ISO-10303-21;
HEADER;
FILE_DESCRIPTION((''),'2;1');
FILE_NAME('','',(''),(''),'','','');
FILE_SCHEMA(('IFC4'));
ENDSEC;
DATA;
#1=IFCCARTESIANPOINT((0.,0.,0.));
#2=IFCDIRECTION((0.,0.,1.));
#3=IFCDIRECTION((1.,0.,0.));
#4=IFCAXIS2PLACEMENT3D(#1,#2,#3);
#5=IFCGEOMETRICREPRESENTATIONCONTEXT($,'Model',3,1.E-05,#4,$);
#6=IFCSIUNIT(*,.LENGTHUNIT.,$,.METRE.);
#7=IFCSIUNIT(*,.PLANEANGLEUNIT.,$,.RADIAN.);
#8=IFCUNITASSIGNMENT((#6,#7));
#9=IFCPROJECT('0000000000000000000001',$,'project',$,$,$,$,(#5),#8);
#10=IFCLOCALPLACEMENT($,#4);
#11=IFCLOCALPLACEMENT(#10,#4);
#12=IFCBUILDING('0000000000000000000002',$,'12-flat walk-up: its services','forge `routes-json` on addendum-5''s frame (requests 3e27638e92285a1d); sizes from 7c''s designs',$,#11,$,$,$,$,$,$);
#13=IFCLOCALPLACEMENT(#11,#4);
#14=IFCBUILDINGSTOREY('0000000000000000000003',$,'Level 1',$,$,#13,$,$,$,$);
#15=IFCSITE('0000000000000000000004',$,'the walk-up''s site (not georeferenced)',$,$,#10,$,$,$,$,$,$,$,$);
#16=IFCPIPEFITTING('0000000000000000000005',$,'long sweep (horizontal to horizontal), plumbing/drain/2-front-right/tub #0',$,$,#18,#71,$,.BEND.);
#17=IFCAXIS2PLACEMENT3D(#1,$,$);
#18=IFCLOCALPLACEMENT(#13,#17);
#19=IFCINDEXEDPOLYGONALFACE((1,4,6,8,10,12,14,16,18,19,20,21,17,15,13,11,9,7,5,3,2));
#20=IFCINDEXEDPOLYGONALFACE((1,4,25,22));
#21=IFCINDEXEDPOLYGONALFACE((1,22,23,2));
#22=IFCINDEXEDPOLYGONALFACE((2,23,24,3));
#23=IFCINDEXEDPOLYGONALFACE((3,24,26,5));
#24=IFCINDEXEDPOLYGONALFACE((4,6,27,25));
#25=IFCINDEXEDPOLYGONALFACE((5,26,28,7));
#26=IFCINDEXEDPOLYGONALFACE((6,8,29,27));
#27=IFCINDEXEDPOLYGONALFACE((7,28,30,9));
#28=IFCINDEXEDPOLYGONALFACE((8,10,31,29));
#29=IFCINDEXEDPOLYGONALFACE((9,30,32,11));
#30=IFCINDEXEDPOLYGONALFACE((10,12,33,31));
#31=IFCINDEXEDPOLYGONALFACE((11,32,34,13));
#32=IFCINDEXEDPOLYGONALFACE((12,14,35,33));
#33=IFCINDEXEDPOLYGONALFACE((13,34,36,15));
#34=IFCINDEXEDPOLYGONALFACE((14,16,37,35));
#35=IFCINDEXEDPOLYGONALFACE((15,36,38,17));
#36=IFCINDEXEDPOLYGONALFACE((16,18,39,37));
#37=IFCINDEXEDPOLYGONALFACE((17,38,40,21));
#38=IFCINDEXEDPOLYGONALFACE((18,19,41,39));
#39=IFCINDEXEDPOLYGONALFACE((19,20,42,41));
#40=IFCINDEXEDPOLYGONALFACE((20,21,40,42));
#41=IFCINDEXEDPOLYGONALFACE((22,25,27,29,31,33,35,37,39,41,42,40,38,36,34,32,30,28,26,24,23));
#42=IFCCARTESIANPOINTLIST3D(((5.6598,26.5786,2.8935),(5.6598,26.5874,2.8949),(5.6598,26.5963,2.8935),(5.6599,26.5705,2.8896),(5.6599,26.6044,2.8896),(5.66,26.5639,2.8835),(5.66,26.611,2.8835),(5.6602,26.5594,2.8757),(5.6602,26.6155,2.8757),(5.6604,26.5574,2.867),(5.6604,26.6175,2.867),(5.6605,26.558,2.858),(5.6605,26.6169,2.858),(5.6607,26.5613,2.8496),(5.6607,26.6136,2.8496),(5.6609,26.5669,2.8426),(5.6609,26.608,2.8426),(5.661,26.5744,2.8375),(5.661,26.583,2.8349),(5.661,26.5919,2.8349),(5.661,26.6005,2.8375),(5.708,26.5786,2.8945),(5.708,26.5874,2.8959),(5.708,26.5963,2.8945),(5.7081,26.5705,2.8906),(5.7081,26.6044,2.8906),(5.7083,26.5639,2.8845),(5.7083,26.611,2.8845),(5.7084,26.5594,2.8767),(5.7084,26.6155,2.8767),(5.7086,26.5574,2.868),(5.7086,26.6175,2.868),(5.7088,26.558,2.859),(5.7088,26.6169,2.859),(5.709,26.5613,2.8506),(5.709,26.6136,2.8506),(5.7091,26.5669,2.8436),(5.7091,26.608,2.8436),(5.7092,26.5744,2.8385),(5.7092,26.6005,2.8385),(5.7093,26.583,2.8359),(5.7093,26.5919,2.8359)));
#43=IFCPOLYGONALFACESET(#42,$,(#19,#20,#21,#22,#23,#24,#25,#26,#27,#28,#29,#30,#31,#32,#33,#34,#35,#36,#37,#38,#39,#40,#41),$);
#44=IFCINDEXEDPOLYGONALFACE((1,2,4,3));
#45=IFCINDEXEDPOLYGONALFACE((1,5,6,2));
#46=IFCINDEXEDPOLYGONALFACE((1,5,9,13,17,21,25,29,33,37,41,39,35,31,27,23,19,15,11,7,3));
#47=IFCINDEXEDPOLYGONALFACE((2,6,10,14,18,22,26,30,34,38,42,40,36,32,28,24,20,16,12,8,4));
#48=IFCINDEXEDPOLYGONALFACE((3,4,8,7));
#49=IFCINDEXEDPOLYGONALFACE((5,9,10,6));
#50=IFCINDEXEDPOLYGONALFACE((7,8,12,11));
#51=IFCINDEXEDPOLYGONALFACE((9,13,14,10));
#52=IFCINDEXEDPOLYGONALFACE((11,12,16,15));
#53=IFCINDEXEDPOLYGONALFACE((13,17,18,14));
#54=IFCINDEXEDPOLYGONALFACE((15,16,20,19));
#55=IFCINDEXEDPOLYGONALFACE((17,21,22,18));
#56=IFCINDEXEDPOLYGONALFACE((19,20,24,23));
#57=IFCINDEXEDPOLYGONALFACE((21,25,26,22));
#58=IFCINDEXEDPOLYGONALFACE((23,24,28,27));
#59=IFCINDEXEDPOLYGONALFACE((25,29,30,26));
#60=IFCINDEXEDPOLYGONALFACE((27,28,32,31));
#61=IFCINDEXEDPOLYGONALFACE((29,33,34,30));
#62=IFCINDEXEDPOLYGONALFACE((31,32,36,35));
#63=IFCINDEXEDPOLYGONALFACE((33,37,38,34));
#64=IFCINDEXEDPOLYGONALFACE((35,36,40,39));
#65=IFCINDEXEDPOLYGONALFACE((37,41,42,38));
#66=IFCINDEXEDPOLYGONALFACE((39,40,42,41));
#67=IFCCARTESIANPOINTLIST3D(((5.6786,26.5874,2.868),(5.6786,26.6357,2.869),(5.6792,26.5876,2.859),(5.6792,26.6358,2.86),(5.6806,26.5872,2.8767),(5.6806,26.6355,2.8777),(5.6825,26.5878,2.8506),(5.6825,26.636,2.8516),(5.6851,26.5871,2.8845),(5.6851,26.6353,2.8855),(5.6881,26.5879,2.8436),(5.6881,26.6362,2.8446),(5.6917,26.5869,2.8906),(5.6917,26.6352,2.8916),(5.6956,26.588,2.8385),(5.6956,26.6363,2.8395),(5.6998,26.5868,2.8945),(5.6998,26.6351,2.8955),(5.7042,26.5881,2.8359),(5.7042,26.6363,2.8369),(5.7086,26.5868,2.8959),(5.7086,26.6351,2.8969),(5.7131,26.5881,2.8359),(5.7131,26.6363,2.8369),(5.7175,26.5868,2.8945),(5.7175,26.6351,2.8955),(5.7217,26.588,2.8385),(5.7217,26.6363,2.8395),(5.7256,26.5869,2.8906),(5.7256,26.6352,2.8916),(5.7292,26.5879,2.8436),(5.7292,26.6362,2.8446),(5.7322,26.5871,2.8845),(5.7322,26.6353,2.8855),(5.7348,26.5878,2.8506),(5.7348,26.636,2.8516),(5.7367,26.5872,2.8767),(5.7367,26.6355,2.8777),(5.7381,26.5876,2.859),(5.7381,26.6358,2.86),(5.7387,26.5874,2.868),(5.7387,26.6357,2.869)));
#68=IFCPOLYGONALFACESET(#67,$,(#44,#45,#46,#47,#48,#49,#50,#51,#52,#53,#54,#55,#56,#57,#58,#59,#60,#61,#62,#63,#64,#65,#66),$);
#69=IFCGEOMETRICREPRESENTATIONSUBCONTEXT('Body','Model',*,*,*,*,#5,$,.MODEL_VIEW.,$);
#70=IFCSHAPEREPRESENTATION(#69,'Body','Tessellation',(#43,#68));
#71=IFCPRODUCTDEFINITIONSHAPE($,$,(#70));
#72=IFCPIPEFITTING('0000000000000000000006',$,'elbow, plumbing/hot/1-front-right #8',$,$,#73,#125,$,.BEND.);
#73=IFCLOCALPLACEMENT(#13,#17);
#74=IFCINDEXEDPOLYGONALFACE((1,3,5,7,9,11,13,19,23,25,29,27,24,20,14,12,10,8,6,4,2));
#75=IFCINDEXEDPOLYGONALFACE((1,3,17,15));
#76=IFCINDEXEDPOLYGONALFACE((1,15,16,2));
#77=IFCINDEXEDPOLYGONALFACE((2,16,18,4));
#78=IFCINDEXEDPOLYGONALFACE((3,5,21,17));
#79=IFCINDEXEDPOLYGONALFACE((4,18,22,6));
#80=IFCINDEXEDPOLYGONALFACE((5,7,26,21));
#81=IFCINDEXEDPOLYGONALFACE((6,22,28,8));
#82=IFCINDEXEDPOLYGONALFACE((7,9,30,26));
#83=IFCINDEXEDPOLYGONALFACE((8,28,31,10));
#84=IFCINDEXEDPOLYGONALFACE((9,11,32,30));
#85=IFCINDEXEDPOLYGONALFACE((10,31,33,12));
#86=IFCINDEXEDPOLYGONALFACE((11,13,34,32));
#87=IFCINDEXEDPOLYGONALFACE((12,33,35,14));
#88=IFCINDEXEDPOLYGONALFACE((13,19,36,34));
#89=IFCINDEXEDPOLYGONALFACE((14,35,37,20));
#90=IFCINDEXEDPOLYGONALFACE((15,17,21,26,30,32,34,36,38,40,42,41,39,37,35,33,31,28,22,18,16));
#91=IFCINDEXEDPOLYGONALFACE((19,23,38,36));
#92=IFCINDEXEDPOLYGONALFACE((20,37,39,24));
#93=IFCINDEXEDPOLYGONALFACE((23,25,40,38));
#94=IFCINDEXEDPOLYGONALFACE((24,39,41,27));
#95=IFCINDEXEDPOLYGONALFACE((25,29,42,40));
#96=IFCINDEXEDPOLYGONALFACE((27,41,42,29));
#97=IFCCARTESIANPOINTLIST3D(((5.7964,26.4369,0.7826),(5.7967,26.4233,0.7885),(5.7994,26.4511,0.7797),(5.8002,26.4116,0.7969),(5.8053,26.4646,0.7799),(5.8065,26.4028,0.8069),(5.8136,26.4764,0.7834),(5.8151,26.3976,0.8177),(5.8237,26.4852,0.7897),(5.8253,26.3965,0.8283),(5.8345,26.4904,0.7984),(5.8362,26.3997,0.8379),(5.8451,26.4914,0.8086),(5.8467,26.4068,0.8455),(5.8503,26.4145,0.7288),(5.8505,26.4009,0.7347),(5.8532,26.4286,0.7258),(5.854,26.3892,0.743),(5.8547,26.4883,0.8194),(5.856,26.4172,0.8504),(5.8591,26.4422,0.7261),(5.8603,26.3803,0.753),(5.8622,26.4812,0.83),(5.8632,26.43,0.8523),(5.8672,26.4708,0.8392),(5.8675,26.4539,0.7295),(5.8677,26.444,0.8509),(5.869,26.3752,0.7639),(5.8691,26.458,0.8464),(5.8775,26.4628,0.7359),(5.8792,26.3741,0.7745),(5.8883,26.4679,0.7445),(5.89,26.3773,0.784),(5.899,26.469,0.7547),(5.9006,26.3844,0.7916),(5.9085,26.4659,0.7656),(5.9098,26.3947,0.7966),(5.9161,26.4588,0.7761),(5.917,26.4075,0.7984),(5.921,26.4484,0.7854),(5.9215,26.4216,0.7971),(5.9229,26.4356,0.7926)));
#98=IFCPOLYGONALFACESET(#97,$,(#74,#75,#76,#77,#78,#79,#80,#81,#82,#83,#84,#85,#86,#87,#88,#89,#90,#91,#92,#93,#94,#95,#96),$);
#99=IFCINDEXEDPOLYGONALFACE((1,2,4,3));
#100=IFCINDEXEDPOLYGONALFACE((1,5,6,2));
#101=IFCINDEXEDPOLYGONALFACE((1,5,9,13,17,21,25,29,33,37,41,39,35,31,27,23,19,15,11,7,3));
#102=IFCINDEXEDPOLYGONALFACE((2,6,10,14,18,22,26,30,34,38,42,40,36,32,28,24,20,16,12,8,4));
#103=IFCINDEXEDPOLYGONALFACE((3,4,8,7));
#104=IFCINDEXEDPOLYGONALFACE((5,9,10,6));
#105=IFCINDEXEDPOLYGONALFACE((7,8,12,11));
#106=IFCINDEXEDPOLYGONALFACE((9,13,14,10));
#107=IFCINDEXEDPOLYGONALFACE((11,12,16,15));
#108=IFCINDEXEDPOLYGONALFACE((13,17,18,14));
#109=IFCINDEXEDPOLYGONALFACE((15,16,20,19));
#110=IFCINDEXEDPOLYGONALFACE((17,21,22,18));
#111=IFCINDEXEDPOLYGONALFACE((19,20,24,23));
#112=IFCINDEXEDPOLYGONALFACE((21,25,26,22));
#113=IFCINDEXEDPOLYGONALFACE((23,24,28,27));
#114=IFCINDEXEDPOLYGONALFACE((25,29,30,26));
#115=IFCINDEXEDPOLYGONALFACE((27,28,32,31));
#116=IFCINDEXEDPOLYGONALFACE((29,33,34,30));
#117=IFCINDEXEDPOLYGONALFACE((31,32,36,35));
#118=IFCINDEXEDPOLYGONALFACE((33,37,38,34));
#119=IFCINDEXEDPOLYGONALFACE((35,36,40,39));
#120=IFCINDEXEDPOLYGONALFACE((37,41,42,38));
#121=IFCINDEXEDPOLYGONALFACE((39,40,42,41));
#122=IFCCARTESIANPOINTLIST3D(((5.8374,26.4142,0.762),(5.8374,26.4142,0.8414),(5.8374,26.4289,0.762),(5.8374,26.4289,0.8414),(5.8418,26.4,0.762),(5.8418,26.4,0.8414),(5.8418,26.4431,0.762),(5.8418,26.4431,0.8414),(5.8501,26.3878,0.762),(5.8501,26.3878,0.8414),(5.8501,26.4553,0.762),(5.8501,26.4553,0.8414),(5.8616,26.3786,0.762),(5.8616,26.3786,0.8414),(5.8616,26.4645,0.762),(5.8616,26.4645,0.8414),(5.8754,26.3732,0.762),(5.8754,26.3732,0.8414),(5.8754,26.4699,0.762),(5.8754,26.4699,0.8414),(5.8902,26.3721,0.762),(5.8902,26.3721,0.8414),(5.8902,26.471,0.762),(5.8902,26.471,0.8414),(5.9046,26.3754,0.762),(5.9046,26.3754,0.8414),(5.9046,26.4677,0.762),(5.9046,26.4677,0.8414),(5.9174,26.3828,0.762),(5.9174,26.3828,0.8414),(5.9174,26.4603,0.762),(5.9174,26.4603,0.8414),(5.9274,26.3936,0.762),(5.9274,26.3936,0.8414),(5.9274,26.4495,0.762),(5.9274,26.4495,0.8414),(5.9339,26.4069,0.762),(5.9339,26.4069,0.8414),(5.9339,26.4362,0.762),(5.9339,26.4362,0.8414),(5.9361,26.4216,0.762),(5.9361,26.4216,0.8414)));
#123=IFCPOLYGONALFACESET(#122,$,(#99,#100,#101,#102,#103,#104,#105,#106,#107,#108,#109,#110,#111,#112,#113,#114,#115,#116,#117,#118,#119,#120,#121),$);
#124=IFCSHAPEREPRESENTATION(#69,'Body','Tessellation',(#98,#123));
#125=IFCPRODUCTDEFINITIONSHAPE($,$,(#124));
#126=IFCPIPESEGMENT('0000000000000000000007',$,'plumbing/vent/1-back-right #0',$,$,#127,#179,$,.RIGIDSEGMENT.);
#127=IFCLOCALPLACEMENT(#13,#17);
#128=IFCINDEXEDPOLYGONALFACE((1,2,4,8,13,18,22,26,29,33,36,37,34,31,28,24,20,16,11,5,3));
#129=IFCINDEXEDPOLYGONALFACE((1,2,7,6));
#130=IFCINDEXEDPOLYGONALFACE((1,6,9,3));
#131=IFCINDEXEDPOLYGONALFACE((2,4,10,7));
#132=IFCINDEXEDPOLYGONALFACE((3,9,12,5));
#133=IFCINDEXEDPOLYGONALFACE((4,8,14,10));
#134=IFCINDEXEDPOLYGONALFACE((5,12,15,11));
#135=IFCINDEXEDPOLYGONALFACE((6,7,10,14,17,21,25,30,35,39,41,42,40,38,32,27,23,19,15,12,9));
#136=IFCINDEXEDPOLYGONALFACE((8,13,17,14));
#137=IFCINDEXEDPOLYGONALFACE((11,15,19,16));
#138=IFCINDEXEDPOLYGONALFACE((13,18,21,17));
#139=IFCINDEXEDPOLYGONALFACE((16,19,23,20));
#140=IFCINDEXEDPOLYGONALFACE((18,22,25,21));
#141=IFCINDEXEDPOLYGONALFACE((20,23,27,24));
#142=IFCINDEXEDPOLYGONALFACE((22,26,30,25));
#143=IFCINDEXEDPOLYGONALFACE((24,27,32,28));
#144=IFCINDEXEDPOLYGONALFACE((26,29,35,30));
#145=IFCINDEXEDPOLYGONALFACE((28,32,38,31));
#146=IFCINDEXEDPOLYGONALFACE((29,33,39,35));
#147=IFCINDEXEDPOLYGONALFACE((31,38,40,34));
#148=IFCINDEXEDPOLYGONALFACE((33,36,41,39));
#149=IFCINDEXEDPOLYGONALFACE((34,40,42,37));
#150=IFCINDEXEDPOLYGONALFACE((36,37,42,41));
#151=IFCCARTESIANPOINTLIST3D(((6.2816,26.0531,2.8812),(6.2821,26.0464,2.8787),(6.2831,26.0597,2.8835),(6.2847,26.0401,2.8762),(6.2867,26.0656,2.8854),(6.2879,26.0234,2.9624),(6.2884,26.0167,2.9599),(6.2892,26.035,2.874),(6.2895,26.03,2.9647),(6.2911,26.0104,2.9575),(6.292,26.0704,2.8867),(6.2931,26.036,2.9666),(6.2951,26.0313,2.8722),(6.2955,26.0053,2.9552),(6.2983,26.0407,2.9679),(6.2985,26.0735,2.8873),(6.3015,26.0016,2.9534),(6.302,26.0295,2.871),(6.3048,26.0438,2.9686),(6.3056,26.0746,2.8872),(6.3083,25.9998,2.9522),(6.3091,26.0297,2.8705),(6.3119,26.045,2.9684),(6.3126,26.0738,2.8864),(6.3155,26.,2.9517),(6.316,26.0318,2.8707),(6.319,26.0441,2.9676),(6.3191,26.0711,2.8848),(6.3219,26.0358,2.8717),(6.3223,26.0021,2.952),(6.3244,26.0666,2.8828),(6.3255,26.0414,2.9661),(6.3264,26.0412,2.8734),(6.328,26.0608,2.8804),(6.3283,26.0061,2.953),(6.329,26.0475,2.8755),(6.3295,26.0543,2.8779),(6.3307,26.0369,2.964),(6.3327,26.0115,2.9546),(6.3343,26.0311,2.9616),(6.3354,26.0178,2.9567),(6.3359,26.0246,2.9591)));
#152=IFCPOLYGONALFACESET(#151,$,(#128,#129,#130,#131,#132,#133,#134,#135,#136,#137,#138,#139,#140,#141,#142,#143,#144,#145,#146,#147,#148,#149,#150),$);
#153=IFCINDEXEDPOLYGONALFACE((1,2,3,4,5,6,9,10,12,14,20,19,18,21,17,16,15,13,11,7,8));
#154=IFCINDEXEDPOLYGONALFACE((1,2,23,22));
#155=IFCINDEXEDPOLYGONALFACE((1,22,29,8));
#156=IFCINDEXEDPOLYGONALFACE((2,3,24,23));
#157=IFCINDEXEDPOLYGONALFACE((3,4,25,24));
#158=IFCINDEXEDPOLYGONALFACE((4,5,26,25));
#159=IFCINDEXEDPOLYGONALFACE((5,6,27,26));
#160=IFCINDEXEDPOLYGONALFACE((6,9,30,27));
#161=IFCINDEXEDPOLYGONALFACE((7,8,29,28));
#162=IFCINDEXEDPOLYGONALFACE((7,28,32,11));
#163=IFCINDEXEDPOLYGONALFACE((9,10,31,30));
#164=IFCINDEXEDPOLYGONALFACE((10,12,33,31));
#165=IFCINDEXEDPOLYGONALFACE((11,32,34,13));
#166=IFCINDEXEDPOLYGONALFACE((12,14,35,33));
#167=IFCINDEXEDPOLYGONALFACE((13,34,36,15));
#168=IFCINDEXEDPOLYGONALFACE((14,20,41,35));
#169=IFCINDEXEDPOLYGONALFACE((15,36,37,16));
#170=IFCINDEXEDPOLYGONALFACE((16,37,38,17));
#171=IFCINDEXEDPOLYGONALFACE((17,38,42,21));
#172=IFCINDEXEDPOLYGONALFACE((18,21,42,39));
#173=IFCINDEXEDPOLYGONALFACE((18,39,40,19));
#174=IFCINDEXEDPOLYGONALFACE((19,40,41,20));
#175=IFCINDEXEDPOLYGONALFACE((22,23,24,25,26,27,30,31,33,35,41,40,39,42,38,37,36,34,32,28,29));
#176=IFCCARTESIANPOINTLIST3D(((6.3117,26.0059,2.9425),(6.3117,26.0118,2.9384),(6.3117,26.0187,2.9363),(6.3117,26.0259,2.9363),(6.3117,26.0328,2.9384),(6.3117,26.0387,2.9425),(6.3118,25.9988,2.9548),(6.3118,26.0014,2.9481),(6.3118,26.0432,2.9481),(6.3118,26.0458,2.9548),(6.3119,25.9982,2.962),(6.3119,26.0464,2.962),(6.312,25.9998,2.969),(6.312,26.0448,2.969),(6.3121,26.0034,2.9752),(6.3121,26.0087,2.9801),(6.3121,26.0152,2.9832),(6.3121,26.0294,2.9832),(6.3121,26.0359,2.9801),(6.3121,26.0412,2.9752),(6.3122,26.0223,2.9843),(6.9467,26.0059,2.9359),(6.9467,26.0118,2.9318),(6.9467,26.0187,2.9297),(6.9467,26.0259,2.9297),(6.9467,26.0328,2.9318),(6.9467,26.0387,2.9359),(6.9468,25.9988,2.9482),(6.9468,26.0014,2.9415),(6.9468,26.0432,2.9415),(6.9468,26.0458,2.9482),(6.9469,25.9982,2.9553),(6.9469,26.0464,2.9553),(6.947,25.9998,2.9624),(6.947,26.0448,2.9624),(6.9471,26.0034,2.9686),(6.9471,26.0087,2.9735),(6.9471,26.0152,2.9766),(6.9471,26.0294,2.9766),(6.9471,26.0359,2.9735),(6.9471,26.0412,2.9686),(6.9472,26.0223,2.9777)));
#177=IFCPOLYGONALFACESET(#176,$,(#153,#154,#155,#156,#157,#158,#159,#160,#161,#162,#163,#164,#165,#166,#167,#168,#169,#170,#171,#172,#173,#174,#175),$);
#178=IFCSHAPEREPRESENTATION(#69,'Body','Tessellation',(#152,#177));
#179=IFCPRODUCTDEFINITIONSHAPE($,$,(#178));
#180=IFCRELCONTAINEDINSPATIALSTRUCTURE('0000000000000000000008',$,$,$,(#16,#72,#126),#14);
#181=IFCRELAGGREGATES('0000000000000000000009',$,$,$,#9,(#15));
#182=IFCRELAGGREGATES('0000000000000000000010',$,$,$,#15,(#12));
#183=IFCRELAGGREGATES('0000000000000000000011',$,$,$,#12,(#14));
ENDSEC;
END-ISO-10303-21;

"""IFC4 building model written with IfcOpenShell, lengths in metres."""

from ifc_helpers import new_model, entity, si_unit, frame, origin_with_axes, place, context, subcontext, project, spatial, element, save


model = new_model("IFC4")

# Units and contexts
model_context = context("Model", 3, precision=1e-05, world=origin_with_axes())
body_context = subcontext(model_context, "Body", "Model", "MODEL_VIEW")
ifc_project = project(units=[si_unit("LENGTHUNIT", "METRE"), si_unit("PLANEANGLEUNIT", "RADIAN")], contexts=[model_context])

# Site, building, storey
site_placement = place(None, origin_with_axes())
site = spatial("IfcSite", under=ifc_project, at=site_placement, Name="the walk-up's site (not georeferenced)")
building_placement = place(site_placement, origin_with_axes())
building = spatial("IfcBuilding", under=site, at=building_placement, Name="12-flat walk-up: its services", Description="forge `routes-json` on addendum-5's frame (requests 3e27638e92285a1d); sizes from 7c's designs")
storey_placement = place(building_placement, origin_with_axes())
storey = spatial("IfcBuildingStorey", under=building, at=storey_placement, Name="Level 1")

# Pipe fittings
pipe_fitting_1_placement = place(storey_placement, frame((5.6604, 26.5875, 2.8647), z_axis=(0.0, 0.0, 1.0), x_axis=(1.0, 0.0, 0.0)))
element("IfcPipeFitting", 1, at=pipe_fitting_1_placement, inside=storey, Name="long sweep (horizontal to horizontal), plumbing/drain/2-front-right/tub #0", PredefinedType="BEND", context=body_context, shape_type="AdvancedSweptSolid", body=[
    entity("IfcSweptDiskSolid", entity("IfcPolyline", [entity("IfcCartesianPoint", [0.0, 0.0, 0.0]), entity("IfcCartesianPoint", [0.0482, 0.0, 0.001])]), 0.0302),
    entity("IfcSweptDiskSolid", entity("IfcPolyline", [entity("IfcCartesianPoint", [0.0482, 0.0, 0.001]), entity("IfcCartesianPoint", [0.0482, 0.0482, 0.002])]), 0.0302),
])
pipe_fitting_2_placement = place(storey_placement, frame((5.8326, 26.444, 0.8158), z_axis=(0.0, 0.0, 1.0), x_axis=(1.0, 0.0, 0.0)))
element("IfcPipeFitting", 2, at=pipe_fitting_2_placement, inside=storey, Name="elbow, plumbing/hot/1-front-right #8", PredefinedType="BEND", context=body_context, shape_type="AdvancedSweptSolid", body=[
    entity("IfcSweptDiskSolid", entity("IfcPolyline", [entity("IfcCartesianPoint", [0.0, 0.0, 0.0]), entity("IfcCartesianPoint", [0.0538, -0.0224, -0.0538])]), 0.0496),
    entity("IfcSweptDiskSolid", entity("IfcPolyline", [entity("IfcCartesianPoint", [0.0538, -0.0224, -0.0538]), entity("IfcCartesianPoint", [0.0538, -0.0224, 0.0255])]), 0.0496),
])

# Pipe segment
pipe_segment_1_placement = place(storey_placement, frame((6.3056, 26.052, 2.8789), z_axis=(0.0, 0.0, 1.0), x_axis=(1.0, 0.0, 0.0)))
element("IfcPipeSegment", 3, at=pipe_segment_1_placement, inside=storey, Name="plumbing/vent/1-back-right #0", PredefinedType="RIGIDSEGMENT", context=body_context, shape_type="AdvancedSweptSolid", body=[
    entity("IfcSweptDiskSolid", entity("IfcPolyline", [entity("IfcCartesianPoint", [0.0, 0.0, 0.0]), entity("IfcCartesianPoint", [0.0063, -0.0297, 0.0812])]), 0.0241),
    entity("IfcSweptDiskSolid", entity("IfcPolyline", [entity("IfcCartesianPoint", [0.0063, -0.0297, 0.0812]), entity("IfcCartesianPoint", [0.6413, -0.0297, 0.0746])]), 0.0241),
])

save(model, "model.ifc")
